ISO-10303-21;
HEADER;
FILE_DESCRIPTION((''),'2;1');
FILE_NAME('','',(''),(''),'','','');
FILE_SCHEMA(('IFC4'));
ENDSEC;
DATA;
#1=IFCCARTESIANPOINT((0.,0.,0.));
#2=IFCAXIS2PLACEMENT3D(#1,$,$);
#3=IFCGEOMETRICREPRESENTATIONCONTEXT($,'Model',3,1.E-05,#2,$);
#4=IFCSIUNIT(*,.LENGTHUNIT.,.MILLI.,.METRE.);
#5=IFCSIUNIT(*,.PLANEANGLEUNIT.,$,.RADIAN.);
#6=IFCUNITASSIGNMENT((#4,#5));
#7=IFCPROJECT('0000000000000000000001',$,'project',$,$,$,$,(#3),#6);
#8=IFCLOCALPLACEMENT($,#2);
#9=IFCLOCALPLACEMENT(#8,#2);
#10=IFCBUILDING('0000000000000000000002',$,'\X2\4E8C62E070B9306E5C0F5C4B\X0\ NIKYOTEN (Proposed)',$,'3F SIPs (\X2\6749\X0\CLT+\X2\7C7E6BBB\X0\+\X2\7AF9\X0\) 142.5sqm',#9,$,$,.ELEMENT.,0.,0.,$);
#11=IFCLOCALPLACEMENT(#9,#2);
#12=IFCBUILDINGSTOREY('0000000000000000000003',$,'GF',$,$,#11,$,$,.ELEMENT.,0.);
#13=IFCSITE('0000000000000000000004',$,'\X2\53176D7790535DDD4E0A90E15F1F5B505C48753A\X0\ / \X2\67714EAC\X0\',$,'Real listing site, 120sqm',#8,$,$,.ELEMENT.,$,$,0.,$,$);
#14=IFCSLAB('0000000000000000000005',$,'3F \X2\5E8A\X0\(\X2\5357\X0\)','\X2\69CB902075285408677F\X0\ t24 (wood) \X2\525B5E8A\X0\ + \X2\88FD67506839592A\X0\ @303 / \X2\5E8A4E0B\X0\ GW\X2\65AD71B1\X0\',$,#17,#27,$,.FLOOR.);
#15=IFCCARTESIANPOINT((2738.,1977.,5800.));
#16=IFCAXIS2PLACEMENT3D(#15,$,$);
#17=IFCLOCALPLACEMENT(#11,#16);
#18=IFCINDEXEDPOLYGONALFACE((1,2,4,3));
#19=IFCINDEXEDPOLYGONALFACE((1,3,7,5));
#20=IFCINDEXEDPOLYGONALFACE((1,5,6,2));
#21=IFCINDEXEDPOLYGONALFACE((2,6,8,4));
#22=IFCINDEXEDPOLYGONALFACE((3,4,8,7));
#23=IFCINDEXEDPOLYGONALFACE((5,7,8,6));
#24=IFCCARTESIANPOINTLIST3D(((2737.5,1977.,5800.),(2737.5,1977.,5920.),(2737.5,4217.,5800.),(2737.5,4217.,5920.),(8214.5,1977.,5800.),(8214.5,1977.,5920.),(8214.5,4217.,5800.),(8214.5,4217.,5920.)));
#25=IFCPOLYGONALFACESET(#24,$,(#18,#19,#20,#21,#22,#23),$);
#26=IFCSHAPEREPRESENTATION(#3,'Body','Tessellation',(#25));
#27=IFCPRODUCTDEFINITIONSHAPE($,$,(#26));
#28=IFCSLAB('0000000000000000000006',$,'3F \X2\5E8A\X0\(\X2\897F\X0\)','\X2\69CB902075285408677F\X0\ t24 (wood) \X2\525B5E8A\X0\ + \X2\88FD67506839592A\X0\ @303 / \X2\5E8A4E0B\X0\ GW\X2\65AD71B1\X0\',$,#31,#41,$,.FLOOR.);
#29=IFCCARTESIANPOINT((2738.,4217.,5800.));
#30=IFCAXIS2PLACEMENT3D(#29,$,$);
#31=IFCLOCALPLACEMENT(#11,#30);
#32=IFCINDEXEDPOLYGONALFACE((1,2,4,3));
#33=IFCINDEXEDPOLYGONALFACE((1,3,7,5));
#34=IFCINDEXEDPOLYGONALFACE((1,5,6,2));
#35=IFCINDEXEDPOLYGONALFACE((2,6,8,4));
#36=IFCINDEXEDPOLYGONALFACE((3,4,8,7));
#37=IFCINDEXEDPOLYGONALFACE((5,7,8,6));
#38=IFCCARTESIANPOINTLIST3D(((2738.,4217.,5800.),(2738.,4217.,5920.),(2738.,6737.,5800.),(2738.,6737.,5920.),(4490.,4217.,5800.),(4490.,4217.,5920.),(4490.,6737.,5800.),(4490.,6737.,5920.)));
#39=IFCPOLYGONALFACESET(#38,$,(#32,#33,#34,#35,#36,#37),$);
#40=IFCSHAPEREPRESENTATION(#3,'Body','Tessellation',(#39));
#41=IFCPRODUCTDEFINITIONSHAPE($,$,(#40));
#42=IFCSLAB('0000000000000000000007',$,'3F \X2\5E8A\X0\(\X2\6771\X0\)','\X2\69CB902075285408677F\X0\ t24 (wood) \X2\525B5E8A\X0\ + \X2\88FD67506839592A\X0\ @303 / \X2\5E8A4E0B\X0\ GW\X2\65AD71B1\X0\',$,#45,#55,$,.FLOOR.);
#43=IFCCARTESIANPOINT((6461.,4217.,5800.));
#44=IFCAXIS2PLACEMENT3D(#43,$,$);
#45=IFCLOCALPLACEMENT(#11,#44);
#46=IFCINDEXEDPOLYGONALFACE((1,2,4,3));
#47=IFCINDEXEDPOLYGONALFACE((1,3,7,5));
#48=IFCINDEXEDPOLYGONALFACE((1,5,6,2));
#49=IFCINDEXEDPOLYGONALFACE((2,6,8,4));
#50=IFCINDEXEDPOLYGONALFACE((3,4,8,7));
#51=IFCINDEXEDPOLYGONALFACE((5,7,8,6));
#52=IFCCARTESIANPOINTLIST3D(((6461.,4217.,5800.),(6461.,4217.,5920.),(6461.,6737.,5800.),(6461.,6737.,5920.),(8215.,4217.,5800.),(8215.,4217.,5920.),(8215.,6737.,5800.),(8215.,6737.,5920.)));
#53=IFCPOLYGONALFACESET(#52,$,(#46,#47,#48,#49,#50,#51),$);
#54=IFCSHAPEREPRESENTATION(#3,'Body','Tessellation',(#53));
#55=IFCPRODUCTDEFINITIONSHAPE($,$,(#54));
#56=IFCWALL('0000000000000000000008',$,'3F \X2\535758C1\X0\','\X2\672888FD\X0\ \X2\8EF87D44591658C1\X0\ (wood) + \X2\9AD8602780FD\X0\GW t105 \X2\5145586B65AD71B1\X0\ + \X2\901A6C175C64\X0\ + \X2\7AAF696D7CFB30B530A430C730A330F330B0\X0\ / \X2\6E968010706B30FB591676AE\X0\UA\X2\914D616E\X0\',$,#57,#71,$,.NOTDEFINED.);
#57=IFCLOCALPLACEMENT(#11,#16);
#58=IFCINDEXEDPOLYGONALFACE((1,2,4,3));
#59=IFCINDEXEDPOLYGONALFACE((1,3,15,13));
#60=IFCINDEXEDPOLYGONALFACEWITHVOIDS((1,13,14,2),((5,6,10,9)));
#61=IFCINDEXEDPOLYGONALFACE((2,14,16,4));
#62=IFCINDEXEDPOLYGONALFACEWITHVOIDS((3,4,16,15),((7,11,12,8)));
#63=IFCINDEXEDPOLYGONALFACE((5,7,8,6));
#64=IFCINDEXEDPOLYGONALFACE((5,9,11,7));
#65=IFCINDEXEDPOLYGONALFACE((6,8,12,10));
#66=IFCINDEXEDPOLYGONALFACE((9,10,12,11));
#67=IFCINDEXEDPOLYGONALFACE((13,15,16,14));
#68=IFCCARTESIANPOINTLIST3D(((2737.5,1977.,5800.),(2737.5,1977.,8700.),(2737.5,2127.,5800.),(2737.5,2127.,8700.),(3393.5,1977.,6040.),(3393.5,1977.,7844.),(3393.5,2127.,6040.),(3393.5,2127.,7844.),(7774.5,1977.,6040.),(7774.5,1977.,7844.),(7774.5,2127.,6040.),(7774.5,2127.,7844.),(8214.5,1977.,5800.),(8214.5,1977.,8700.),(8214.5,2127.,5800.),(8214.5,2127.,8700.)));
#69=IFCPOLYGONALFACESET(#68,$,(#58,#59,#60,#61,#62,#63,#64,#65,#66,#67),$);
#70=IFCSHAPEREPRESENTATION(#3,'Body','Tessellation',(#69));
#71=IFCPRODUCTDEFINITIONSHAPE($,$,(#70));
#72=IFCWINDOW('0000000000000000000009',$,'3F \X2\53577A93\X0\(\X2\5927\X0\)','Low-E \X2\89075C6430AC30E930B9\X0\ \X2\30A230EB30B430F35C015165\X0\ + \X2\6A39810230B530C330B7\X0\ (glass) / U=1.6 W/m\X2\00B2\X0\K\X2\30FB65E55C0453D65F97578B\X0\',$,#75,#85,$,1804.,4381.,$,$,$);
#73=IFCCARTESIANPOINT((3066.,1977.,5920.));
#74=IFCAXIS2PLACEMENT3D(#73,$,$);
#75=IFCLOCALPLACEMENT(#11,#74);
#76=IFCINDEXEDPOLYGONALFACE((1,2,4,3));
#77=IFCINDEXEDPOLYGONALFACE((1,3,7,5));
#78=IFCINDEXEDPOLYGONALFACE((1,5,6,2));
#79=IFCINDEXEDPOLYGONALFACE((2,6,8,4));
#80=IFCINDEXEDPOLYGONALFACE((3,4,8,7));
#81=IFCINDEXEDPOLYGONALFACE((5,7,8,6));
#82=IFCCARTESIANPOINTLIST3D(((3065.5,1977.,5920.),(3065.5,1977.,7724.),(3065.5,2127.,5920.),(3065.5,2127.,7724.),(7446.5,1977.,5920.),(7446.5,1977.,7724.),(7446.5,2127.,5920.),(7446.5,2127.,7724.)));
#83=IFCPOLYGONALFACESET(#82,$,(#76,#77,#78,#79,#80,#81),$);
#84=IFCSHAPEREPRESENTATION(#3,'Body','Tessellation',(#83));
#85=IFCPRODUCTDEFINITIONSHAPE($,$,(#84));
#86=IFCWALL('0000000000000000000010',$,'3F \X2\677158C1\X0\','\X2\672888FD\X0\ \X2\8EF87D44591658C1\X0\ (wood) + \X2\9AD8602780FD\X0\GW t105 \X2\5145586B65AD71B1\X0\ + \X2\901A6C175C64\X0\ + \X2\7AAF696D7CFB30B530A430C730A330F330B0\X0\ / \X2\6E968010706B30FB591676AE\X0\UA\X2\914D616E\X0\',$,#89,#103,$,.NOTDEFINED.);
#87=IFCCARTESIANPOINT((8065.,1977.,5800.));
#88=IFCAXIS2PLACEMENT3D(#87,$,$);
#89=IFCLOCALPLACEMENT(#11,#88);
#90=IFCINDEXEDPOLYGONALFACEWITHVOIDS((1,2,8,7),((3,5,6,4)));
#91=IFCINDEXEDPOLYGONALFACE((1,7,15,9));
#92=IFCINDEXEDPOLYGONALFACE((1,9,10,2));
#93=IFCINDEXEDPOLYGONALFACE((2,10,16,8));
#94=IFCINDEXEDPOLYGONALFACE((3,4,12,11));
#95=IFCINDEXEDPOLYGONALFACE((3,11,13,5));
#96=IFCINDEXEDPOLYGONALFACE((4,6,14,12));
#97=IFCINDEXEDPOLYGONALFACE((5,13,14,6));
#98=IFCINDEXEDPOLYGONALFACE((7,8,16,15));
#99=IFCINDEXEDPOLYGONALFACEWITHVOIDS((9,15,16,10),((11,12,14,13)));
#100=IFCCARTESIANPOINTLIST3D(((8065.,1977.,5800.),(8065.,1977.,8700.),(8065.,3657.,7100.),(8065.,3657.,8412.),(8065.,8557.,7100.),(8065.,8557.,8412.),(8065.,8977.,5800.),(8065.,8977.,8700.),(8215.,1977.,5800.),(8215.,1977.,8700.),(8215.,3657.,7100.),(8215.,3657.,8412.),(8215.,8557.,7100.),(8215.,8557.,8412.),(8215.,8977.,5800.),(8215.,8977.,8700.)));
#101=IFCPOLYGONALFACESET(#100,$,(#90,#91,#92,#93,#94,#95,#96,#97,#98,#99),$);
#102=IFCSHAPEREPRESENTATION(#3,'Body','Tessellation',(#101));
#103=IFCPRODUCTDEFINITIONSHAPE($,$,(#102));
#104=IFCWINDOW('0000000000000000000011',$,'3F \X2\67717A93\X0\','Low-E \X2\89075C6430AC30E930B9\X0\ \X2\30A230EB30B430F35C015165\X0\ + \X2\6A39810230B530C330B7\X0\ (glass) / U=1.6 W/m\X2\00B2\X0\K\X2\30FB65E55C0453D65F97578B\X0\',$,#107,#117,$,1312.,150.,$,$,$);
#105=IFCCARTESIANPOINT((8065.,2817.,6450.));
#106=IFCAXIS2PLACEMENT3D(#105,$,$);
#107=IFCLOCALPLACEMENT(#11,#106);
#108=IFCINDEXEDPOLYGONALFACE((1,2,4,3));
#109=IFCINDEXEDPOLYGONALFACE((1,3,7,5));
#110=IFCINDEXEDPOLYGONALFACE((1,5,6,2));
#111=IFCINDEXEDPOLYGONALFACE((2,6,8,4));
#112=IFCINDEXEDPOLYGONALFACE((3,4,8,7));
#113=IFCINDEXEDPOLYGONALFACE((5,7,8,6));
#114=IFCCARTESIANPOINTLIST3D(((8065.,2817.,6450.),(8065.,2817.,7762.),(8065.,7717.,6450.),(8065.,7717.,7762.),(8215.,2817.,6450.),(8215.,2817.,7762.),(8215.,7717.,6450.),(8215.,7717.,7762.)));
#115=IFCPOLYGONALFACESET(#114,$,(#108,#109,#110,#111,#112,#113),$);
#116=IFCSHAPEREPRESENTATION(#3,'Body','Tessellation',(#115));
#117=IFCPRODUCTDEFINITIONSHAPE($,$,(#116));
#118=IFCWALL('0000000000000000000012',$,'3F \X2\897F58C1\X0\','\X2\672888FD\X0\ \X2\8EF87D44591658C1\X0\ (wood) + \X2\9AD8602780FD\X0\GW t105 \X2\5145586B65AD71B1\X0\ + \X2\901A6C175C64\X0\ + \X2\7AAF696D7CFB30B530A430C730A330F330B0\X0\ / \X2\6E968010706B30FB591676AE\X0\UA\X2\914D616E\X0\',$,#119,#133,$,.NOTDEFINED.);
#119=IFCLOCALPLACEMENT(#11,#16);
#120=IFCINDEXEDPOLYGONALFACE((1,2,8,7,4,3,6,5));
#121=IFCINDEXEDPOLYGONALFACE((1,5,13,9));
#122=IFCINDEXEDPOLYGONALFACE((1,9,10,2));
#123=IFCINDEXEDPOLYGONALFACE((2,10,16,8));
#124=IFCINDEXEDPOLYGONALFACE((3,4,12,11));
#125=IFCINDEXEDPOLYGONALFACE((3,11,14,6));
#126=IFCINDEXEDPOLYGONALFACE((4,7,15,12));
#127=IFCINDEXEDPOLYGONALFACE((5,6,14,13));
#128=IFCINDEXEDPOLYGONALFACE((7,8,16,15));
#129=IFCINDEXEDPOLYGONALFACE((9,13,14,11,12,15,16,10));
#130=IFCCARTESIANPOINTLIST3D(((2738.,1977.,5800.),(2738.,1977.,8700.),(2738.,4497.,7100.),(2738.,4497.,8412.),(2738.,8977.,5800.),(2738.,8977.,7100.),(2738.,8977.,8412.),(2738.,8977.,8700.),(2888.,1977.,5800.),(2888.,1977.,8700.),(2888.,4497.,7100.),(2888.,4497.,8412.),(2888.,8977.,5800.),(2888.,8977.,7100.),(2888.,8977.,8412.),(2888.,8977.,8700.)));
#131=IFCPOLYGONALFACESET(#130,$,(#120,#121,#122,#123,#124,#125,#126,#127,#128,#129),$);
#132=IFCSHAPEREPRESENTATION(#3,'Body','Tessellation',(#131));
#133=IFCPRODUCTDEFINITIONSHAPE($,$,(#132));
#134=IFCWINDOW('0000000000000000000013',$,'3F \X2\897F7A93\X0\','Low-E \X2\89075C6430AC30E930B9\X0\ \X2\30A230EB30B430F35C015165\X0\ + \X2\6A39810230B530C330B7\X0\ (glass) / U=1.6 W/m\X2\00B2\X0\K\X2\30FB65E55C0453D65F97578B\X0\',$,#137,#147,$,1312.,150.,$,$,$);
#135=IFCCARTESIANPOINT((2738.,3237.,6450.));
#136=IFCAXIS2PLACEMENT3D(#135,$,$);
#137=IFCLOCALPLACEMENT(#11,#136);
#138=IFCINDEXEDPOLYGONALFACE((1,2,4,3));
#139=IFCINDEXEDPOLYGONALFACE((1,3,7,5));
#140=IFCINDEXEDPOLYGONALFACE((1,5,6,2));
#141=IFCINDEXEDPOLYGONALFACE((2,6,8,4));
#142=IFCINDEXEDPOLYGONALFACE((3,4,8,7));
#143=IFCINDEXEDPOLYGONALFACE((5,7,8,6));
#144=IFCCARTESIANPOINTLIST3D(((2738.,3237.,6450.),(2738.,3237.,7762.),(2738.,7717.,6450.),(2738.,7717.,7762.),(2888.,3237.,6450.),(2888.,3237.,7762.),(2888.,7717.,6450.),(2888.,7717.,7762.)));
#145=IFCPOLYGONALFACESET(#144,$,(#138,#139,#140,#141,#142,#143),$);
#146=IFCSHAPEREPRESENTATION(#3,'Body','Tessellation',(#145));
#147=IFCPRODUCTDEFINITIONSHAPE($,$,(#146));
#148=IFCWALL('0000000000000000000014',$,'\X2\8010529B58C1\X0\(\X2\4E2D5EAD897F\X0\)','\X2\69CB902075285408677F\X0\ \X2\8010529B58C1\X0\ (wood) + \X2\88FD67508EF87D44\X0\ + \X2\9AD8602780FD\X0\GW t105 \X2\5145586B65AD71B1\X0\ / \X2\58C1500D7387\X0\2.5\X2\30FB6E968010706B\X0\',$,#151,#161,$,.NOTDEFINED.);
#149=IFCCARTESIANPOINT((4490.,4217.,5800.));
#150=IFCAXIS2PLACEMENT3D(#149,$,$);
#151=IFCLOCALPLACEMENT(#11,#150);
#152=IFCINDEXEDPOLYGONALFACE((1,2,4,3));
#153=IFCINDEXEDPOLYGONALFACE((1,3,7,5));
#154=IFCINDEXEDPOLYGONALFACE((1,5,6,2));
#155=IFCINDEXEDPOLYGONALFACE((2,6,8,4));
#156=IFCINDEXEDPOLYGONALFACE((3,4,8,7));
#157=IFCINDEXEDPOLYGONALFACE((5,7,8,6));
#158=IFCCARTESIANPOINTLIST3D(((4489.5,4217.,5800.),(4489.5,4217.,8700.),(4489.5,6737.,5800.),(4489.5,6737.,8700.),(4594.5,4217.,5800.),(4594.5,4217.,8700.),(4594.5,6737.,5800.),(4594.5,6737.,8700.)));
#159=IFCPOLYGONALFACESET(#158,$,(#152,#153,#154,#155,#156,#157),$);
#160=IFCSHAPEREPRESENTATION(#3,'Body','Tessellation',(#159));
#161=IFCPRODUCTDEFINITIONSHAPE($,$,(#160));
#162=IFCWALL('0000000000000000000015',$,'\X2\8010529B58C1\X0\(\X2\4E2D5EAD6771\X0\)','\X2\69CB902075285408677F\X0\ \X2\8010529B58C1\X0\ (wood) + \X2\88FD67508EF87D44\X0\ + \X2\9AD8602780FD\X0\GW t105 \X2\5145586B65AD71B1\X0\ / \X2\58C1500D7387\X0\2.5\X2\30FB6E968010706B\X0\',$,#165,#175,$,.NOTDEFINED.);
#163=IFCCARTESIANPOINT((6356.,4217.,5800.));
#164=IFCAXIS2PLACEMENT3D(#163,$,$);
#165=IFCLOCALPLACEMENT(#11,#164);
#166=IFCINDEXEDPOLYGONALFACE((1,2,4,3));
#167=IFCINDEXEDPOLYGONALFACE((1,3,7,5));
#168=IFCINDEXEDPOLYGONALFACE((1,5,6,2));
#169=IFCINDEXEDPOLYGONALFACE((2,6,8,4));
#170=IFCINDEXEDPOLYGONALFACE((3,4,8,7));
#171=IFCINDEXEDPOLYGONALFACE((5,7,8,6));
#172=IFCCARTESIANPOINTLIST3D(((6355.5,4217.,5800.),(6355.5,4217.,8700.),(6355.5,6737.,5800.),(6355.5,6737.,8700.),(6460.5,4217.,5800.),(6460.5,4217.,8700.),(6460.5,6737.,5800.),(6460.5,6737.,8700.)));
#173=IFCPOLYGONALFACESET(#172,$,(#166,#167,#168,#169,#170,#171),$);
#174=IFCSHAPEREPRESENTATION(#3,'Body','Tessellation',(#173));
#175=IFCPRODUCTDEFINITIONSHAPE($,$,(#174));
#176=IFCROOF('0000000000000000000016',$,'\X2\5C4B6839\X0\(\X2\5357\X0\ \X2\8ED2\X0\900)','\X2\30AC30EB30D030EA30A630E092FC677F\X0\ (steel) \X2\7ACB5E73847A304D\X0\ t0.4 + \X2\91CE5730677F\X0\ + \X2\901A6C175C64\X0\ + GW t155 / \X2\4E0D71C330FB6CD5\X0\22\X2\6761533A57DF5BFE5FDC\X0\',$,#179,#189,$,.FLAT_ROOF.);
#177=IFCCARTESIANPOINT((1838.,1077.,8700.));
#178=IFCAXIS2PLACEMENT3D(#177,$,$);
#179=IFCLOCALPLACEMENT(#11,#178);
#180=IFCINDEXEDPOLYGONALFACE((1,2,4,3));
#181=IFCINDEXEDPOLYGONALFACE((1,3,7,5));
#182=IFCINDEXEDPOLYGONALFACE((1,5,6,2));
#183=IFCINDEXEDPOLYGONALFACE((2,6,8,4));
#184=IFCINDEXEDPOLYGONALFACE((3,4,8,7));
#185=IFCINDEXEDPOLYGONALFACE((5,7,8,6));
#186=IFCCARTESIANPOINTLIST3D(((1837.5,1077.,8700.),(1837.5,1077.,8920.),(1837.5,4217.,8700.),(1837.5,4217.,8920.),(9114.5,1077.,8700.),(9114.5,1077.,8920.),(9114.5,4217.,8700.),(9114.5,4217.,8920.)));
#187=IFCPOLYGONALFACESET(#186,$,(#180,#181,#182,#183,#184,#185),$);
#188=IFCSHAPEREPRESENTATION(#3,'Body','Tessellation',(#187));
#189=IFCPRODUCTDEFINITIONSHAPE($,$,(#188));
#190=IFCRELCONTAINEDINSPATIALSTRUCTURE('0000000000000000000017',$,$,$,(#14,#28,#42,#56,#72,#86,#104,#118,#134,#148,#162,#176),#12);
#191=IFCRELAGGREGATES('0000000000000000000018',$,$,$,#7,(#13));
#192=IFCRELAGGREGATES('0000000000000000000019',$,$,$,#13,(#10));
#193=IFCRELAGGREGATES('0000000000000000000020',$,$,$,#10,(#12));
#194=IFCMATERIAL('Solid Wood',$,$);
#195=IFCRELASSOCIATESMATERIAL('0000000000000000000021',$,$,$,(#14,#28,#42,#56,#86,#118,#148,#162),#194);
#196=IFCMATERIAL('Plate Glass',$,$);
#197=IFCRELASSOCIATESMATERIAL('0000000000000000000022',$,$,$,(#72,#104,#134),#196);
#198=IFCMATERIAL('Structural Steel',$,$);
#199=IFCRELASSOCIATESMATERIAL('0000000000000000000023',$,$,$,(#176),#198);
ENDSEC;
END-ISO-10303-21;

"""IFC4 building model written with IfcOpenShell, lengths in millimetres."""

from ifc_helpers import new_model, si_unit, frame, frame_2d, origin, place, context, project, spatial, rectangle, extrude, material, element, fill, save


model = new_model("IFC4")

# Units and contexts
model_context = context("Model", 3, precision=1e-05, world=origin())
ifc_project = project(units=[si_unit("LENGTHUNIT", "METRE", prefix="MILLI"), si_unit("PLANEANGLEUNIT", "RADIAN")], contexts=[model_context])

# Site, building, storey
site_placement = place(None, origin())
site = spatial("IfcSite", under=ifc_project, at=site_placement, Name="北海道川上郡弟子屈町 / 東京", ObjectType="Real listing site, 120sqm", CompositionType="ELEMENT", RefElevation=0.0)
building_placement = place(site_placement, origin())
building = spatial("IfcBuilding", under=site, at=building_placement, Name="二拠点の小屋 NIKYOTEN (Proposed)", ObjectType="3F SIPs (杉CLT+籾殻+竹) 142.5sqm", CompositionType="ELEMENT", ElevationOfRefHeight=0.0, ElevationOfTerrain=0.0)
storey_placement = place(building_placement, origin())
storey = spatial("IfcBuildingStorey", under=building, at=storey_placement, Name="GF", CompositionType="ELEMENT", Elevation=0.0)

# Slabs
ifc_material_1 = material(Name="Solid Wood")
slab_1_placement = place(storey_placement, frame((2738.0, 1977.0, 5800.0)))
element("IfcSlab", 1, at=slab_1_placement, inside=storey, material=ifc_material_1, Name="3F 床(南)", Description="構造用合板 t24 (wood) 剛床 + 製材根太 @303 / 床下 GW断熱", PredefinedType="FLOOR", context=model_context, shape_type="SweptSolid", body=[
    extrude(rectangle(XDim=5477.0, YDim=2240.0, at=frame_2d((2738.0, 1120.0))), frame((2738.0, 1977.0, 5800.0)), (0.0, 0.0, 1.0), 120.0),
])
slab_2_placement = place(storey_placement, frame((2738.0, 4217.0, 5800.0)))
element("IfcSlab", 2, at=slab_2_placement, inside=storey, material=ifc_material_1, Name="3F 床(西)", Description="構造用合板 t24 (wood) 剛床 + 製材根太 @303 / 床下 GW断熱", PredefinedType="FLOOR", context=model_context, shape_type="SweptSolid", body=[
    extrude(rectangle(XDim=1752.0, YDim=2520.0, at=frame_2d((876.0, 1260.0))), frame((2738.0, 4217.0, 5800.0)), (0.0, 0.0, 1.0), 120.0),
])
slab_3_placement = place(storey_placement, frame((6461.0, 4217.0, 5800.0)))
element("IfcSlab", 3, at=slab_3_placement, inside=storey, material=ifc_material_1, Name="3F 床(東)", Description="構造用合板 t24 (wood) 剛床 + 製材根太 @303 / 床下 GW断熱", PredefinedType="FLOOR", context=model_context, shape_type="SweptSolid", body=[
    extrude(rectangle(XDim=1754.0, YDim=2520.0, at=frame_2d((877.0, 1260.0))), frame((6461.0, 4217.0, 5800.0)), (0.0, 0.0, 1.0), 120.0),
])

# Walls, openings, windows
wall_1_placement = place(storey_placement, frame((2738.0, 1977.0, 5800.0)))
wall_1 = element("IfcWall", 4, at=wall_1_placement, inside=storey, material=ifc_material_1, Name="3F 南壁", Description="木製 軸組外壁 (wood) + 高性能GW t105 充填断熱 + 通気層 + 窯業系サイディング / 準耐火・外皮UA配慮", PredefinedType="NOTDEFINED", context=model_context, shape_type="SweptSolid", body=[
    extrude(rectangle(XDim=5477.0, YDim=150.0, at=frame_2d((2738.0, 75.0))), frame((2738.0, 1977.0, 5800.0)), (0.0, 0.0, 1.0), 2900.0),
])
opening_1_placement = place(storey_placement, frame((3066.0, 1977.0, 5920.0)))
opening_1 = element("IfcOpeningElement", 5, at=opening_1_placement, cuts=wall_1, PredefinedType="NOTDEFINED", context=model_context, shape_type="SweptSolid", body=[
    extrude(rectangle(XDim=4381.0, YDim=150.0, at=frame_2d((2190.0, 75.0))), frame((3066.0, 1977.0, 5920.0)), (0.0, 0.0, 1.0), 1804.0),
])
ifc_material_2 = material(Name="Plate Glass")
window_1_placement = place(storey_placement, frame((3066.0, 1977.0, 5920.0)))
window_1 = element("IfcWindow", 6, at=window_1_placement, inside=storey, material=ifc_material_2, Name="3F 南窓(大)", Description="Low-E 複層ガラス アルゴン封入 + 樹脂サッシ (glass) / U=1.6 W/m²K・日射取得型", OverallHeight=1804.0, OverallWidth=4381.0, context=model_context, shape_type="SweptSolid", body=[
    extrude(rectangle(XDim=4381.0, YDim=150.0, at=frame_2d((2190.0, 75.0))), frame((3066.0, 1977.0, 5920.0)), (0.0, 0.0, 1.0), 1804.0),
])
fill(opening_1, window_1)
wall_2_placement = place(storey_placement, frame((8065.0, 1977.0, 5800.0)))
wall_2 = element("IfcWall", 7, at=wall_2_placement, inside=storey, material=ifc_material_1, Name="3F 東壁", Description="木製 軸組外壁 (wood) + 高性能GW t105 充填断熱 + 通気層 + 窯業系サイディング / 準耐火・外皮UA配慮", PredefinedType="NOTDEFINED", context=model_context, shape_type="SweptSolid", body=[
    extrude(rectangle(XDim=150.0, YDim=7000.0, at=frame_2d((75.0, 3500.0))), frame((8065.0, 1977.0, 5800.0)), (0.0, 0.0, 1.0), 2900.0),
])
opening_2_placement = place(storey_placement, frame((8065.0, 2817.0, 6450.0)))
opening_2 = element("IfcOpeningElement", 8, at=opening_2_placement, cuts=wall_2, PredefinedType="NOTDEFINED", context=model_context, shape_type="SweptSolid", body=[
    extrude(rectangle(XDim=150.0, YDim=4900.0, at=frame_2d((75.0, 2450.0))), frame((8065.0, 2817.0, 6450.0)), (0.0, 0.0, 1.0), 1312.0),
])
window_2_placement = place(storey_placement, frame((8065.0, 2817.0, 6450.0)))
window_2 = element("IfcWindow", 9, at=window_2_placement, inside=storey, material=ifc_material_2, Name="3F 東窓", Description="Low-E 複層ガラス アルゴン封入 + 樹脂サッシ (glass) / U=1.6 W/m²K・日射取得型", OverallHeight=1312.0, OverallWidth=150.0, context=model_context, shape_type="SweptSolid", body=[
    extrude(rectangle(XDim=150.0, YDim=4900.0, at=frame_2d((75.0, 2450.0))), frame((8065.0, 2817.0, 6450.0)), (0.0, 0.0, 1.0), 1312.0),
])
fill(opening_2, window_2)
wall_3_placement = place(storey_placement, frame((2738.0, 1977.0, 5800.0)))
wall_3 = element("IfcWall", 10, at=wall_3_placement, inside=storey, material=ifc_material_1, Name="3F 西壁", Description="木製 軸組外壁 (wood) + 高性能GW t105 充填断熱 + 通気層 + 窯業系サイディング / 準耐火・外皮UA配慮", PredefinedType="NOTDEFINED", context=model_context, shape_type="SweptSolid", body=[
    extrude(rectangle(XDim=150.0, YDim=7000.0, at=frame_2d((75.0, 3500.0))), frame((2738.0, 1977.0, 5800.0)), (0.0, 0.0, 1.0), 2900.0),
])
opening_3_placement = place(storey_placement, frame((2738.0, 3237.0, 6450.0)))
opening_3 = element("IfcOpeningElement", 11, at=opening_3_placement, cuts=wall_3, PredefinedType="NOTDEFINED", context=model_context, shape_type="SweptSolid", body=[
    extrude(rectangle(XDim=150.0, YDim=4480.0, at=frame_2d((75.0, 2240.0))), frame((2738.0, 3237.0, 6450.0)), (0.0, 0.0, 1.0), 1312.0),
])
window_3_placement = place(storey_placement, frame((2738.0, 3237.0, 6450.0)))
window_3 = element("IfcWindow", 12, at=window_3_placement, inside=storey, material=ifc_material_2, Name="3F 西窓", Description="Low-E 複層ガラス アルゴン封入 + 樹脂サッシ (glass) / U=1.6 W/m²K・日射取得型", OverallHeight=1312.0, OverallWidth=150.0, context=model_context, shape_type="SweptSolid", body=[
    extrude(rectangle(XDim=150.0, YDim=4480.0, at=frame_2d((75.0, 2240.0))), frame((2738.0, 3237.0, 6450.0)), (0.0, 0.0, 1.0), 1312.0),
])
fill(opening_3, window_3)

# Walls
wall_4_placement = place(storey_placement, frame((4490.0, 4217.0, 5800.0)))
element("IfcWall", 13, at=wall_4_placement, inside=storey, material=ifc_material_1, Name="耐力壁(中庭西)", Description="構造用合板 耐力壁 (wood) + 製材軸組 + 高性能GW t105 充填断熱 / 壁倍率2.5・準耐火", PredefinedType="NOTDEFINED", context=model_context, shape_type="SweptSolid", body=[
    extrude(rectangle(XDim=105.0, YDim=2520.0, at=frame_2d((52.0, 1260.0))), frame((4490.0, 4217.0, 5800.0)), (0.0, 0.0, 1.0), 2900.0),
])
wall_5_placement = place(storey_placement, frame((6356.0, 4217.0, 5800.0)))
element("IfcWall", 14, at=wall_5_placement, inside=storey, material=ifc_material_1, Name="耐力壁(中庭東)", Description="構造用合板 耐力壁 (wood) + 製材軸組 + 高性能GW t105 充填断熱 / 壁倍率2.5・準耐火", PredefinedType="NOTDEFINED", context=model_context, shape_type="SweptSolid", body=[
    extrude(rectangle(XDim=105.0, YDim=2520.0, at=frame_2d((52.0, 1260.0))), frame((6356.0, 4217.0, 5800.0)), (0.0, 0.0, 1.0), 2900.0),
])

# Roof
ifc_material_3 = material(Name="Structural Steel")
roof_1_placement = place(storey_placement, frame((1838.0, 1077.0, 8700.0)))
element("IfcRoof", 15, at=roof_1_placement, inside=storey, material=ifc_material_3, Name="屋根(南 軒900)", Description="ガルバリウム鋼板 (steel) 立平葺き t0.4 + 野地板 + 通気層 + GW t155 / 不燃・法22条区域対応", PredefinedType="FLAT_ROOF", context=model_context, shape_type="SweptSolid", body=[
    extrude(rectangle(XDim=7277.0, YDim=3140.0, at=frame_2d((3638.0, 1570.0))), frame((1838.0, 1077.0, 8700.0)), (0.0, 0.0, 1.0), 220.0),
])

save(model, "model.ifc")
